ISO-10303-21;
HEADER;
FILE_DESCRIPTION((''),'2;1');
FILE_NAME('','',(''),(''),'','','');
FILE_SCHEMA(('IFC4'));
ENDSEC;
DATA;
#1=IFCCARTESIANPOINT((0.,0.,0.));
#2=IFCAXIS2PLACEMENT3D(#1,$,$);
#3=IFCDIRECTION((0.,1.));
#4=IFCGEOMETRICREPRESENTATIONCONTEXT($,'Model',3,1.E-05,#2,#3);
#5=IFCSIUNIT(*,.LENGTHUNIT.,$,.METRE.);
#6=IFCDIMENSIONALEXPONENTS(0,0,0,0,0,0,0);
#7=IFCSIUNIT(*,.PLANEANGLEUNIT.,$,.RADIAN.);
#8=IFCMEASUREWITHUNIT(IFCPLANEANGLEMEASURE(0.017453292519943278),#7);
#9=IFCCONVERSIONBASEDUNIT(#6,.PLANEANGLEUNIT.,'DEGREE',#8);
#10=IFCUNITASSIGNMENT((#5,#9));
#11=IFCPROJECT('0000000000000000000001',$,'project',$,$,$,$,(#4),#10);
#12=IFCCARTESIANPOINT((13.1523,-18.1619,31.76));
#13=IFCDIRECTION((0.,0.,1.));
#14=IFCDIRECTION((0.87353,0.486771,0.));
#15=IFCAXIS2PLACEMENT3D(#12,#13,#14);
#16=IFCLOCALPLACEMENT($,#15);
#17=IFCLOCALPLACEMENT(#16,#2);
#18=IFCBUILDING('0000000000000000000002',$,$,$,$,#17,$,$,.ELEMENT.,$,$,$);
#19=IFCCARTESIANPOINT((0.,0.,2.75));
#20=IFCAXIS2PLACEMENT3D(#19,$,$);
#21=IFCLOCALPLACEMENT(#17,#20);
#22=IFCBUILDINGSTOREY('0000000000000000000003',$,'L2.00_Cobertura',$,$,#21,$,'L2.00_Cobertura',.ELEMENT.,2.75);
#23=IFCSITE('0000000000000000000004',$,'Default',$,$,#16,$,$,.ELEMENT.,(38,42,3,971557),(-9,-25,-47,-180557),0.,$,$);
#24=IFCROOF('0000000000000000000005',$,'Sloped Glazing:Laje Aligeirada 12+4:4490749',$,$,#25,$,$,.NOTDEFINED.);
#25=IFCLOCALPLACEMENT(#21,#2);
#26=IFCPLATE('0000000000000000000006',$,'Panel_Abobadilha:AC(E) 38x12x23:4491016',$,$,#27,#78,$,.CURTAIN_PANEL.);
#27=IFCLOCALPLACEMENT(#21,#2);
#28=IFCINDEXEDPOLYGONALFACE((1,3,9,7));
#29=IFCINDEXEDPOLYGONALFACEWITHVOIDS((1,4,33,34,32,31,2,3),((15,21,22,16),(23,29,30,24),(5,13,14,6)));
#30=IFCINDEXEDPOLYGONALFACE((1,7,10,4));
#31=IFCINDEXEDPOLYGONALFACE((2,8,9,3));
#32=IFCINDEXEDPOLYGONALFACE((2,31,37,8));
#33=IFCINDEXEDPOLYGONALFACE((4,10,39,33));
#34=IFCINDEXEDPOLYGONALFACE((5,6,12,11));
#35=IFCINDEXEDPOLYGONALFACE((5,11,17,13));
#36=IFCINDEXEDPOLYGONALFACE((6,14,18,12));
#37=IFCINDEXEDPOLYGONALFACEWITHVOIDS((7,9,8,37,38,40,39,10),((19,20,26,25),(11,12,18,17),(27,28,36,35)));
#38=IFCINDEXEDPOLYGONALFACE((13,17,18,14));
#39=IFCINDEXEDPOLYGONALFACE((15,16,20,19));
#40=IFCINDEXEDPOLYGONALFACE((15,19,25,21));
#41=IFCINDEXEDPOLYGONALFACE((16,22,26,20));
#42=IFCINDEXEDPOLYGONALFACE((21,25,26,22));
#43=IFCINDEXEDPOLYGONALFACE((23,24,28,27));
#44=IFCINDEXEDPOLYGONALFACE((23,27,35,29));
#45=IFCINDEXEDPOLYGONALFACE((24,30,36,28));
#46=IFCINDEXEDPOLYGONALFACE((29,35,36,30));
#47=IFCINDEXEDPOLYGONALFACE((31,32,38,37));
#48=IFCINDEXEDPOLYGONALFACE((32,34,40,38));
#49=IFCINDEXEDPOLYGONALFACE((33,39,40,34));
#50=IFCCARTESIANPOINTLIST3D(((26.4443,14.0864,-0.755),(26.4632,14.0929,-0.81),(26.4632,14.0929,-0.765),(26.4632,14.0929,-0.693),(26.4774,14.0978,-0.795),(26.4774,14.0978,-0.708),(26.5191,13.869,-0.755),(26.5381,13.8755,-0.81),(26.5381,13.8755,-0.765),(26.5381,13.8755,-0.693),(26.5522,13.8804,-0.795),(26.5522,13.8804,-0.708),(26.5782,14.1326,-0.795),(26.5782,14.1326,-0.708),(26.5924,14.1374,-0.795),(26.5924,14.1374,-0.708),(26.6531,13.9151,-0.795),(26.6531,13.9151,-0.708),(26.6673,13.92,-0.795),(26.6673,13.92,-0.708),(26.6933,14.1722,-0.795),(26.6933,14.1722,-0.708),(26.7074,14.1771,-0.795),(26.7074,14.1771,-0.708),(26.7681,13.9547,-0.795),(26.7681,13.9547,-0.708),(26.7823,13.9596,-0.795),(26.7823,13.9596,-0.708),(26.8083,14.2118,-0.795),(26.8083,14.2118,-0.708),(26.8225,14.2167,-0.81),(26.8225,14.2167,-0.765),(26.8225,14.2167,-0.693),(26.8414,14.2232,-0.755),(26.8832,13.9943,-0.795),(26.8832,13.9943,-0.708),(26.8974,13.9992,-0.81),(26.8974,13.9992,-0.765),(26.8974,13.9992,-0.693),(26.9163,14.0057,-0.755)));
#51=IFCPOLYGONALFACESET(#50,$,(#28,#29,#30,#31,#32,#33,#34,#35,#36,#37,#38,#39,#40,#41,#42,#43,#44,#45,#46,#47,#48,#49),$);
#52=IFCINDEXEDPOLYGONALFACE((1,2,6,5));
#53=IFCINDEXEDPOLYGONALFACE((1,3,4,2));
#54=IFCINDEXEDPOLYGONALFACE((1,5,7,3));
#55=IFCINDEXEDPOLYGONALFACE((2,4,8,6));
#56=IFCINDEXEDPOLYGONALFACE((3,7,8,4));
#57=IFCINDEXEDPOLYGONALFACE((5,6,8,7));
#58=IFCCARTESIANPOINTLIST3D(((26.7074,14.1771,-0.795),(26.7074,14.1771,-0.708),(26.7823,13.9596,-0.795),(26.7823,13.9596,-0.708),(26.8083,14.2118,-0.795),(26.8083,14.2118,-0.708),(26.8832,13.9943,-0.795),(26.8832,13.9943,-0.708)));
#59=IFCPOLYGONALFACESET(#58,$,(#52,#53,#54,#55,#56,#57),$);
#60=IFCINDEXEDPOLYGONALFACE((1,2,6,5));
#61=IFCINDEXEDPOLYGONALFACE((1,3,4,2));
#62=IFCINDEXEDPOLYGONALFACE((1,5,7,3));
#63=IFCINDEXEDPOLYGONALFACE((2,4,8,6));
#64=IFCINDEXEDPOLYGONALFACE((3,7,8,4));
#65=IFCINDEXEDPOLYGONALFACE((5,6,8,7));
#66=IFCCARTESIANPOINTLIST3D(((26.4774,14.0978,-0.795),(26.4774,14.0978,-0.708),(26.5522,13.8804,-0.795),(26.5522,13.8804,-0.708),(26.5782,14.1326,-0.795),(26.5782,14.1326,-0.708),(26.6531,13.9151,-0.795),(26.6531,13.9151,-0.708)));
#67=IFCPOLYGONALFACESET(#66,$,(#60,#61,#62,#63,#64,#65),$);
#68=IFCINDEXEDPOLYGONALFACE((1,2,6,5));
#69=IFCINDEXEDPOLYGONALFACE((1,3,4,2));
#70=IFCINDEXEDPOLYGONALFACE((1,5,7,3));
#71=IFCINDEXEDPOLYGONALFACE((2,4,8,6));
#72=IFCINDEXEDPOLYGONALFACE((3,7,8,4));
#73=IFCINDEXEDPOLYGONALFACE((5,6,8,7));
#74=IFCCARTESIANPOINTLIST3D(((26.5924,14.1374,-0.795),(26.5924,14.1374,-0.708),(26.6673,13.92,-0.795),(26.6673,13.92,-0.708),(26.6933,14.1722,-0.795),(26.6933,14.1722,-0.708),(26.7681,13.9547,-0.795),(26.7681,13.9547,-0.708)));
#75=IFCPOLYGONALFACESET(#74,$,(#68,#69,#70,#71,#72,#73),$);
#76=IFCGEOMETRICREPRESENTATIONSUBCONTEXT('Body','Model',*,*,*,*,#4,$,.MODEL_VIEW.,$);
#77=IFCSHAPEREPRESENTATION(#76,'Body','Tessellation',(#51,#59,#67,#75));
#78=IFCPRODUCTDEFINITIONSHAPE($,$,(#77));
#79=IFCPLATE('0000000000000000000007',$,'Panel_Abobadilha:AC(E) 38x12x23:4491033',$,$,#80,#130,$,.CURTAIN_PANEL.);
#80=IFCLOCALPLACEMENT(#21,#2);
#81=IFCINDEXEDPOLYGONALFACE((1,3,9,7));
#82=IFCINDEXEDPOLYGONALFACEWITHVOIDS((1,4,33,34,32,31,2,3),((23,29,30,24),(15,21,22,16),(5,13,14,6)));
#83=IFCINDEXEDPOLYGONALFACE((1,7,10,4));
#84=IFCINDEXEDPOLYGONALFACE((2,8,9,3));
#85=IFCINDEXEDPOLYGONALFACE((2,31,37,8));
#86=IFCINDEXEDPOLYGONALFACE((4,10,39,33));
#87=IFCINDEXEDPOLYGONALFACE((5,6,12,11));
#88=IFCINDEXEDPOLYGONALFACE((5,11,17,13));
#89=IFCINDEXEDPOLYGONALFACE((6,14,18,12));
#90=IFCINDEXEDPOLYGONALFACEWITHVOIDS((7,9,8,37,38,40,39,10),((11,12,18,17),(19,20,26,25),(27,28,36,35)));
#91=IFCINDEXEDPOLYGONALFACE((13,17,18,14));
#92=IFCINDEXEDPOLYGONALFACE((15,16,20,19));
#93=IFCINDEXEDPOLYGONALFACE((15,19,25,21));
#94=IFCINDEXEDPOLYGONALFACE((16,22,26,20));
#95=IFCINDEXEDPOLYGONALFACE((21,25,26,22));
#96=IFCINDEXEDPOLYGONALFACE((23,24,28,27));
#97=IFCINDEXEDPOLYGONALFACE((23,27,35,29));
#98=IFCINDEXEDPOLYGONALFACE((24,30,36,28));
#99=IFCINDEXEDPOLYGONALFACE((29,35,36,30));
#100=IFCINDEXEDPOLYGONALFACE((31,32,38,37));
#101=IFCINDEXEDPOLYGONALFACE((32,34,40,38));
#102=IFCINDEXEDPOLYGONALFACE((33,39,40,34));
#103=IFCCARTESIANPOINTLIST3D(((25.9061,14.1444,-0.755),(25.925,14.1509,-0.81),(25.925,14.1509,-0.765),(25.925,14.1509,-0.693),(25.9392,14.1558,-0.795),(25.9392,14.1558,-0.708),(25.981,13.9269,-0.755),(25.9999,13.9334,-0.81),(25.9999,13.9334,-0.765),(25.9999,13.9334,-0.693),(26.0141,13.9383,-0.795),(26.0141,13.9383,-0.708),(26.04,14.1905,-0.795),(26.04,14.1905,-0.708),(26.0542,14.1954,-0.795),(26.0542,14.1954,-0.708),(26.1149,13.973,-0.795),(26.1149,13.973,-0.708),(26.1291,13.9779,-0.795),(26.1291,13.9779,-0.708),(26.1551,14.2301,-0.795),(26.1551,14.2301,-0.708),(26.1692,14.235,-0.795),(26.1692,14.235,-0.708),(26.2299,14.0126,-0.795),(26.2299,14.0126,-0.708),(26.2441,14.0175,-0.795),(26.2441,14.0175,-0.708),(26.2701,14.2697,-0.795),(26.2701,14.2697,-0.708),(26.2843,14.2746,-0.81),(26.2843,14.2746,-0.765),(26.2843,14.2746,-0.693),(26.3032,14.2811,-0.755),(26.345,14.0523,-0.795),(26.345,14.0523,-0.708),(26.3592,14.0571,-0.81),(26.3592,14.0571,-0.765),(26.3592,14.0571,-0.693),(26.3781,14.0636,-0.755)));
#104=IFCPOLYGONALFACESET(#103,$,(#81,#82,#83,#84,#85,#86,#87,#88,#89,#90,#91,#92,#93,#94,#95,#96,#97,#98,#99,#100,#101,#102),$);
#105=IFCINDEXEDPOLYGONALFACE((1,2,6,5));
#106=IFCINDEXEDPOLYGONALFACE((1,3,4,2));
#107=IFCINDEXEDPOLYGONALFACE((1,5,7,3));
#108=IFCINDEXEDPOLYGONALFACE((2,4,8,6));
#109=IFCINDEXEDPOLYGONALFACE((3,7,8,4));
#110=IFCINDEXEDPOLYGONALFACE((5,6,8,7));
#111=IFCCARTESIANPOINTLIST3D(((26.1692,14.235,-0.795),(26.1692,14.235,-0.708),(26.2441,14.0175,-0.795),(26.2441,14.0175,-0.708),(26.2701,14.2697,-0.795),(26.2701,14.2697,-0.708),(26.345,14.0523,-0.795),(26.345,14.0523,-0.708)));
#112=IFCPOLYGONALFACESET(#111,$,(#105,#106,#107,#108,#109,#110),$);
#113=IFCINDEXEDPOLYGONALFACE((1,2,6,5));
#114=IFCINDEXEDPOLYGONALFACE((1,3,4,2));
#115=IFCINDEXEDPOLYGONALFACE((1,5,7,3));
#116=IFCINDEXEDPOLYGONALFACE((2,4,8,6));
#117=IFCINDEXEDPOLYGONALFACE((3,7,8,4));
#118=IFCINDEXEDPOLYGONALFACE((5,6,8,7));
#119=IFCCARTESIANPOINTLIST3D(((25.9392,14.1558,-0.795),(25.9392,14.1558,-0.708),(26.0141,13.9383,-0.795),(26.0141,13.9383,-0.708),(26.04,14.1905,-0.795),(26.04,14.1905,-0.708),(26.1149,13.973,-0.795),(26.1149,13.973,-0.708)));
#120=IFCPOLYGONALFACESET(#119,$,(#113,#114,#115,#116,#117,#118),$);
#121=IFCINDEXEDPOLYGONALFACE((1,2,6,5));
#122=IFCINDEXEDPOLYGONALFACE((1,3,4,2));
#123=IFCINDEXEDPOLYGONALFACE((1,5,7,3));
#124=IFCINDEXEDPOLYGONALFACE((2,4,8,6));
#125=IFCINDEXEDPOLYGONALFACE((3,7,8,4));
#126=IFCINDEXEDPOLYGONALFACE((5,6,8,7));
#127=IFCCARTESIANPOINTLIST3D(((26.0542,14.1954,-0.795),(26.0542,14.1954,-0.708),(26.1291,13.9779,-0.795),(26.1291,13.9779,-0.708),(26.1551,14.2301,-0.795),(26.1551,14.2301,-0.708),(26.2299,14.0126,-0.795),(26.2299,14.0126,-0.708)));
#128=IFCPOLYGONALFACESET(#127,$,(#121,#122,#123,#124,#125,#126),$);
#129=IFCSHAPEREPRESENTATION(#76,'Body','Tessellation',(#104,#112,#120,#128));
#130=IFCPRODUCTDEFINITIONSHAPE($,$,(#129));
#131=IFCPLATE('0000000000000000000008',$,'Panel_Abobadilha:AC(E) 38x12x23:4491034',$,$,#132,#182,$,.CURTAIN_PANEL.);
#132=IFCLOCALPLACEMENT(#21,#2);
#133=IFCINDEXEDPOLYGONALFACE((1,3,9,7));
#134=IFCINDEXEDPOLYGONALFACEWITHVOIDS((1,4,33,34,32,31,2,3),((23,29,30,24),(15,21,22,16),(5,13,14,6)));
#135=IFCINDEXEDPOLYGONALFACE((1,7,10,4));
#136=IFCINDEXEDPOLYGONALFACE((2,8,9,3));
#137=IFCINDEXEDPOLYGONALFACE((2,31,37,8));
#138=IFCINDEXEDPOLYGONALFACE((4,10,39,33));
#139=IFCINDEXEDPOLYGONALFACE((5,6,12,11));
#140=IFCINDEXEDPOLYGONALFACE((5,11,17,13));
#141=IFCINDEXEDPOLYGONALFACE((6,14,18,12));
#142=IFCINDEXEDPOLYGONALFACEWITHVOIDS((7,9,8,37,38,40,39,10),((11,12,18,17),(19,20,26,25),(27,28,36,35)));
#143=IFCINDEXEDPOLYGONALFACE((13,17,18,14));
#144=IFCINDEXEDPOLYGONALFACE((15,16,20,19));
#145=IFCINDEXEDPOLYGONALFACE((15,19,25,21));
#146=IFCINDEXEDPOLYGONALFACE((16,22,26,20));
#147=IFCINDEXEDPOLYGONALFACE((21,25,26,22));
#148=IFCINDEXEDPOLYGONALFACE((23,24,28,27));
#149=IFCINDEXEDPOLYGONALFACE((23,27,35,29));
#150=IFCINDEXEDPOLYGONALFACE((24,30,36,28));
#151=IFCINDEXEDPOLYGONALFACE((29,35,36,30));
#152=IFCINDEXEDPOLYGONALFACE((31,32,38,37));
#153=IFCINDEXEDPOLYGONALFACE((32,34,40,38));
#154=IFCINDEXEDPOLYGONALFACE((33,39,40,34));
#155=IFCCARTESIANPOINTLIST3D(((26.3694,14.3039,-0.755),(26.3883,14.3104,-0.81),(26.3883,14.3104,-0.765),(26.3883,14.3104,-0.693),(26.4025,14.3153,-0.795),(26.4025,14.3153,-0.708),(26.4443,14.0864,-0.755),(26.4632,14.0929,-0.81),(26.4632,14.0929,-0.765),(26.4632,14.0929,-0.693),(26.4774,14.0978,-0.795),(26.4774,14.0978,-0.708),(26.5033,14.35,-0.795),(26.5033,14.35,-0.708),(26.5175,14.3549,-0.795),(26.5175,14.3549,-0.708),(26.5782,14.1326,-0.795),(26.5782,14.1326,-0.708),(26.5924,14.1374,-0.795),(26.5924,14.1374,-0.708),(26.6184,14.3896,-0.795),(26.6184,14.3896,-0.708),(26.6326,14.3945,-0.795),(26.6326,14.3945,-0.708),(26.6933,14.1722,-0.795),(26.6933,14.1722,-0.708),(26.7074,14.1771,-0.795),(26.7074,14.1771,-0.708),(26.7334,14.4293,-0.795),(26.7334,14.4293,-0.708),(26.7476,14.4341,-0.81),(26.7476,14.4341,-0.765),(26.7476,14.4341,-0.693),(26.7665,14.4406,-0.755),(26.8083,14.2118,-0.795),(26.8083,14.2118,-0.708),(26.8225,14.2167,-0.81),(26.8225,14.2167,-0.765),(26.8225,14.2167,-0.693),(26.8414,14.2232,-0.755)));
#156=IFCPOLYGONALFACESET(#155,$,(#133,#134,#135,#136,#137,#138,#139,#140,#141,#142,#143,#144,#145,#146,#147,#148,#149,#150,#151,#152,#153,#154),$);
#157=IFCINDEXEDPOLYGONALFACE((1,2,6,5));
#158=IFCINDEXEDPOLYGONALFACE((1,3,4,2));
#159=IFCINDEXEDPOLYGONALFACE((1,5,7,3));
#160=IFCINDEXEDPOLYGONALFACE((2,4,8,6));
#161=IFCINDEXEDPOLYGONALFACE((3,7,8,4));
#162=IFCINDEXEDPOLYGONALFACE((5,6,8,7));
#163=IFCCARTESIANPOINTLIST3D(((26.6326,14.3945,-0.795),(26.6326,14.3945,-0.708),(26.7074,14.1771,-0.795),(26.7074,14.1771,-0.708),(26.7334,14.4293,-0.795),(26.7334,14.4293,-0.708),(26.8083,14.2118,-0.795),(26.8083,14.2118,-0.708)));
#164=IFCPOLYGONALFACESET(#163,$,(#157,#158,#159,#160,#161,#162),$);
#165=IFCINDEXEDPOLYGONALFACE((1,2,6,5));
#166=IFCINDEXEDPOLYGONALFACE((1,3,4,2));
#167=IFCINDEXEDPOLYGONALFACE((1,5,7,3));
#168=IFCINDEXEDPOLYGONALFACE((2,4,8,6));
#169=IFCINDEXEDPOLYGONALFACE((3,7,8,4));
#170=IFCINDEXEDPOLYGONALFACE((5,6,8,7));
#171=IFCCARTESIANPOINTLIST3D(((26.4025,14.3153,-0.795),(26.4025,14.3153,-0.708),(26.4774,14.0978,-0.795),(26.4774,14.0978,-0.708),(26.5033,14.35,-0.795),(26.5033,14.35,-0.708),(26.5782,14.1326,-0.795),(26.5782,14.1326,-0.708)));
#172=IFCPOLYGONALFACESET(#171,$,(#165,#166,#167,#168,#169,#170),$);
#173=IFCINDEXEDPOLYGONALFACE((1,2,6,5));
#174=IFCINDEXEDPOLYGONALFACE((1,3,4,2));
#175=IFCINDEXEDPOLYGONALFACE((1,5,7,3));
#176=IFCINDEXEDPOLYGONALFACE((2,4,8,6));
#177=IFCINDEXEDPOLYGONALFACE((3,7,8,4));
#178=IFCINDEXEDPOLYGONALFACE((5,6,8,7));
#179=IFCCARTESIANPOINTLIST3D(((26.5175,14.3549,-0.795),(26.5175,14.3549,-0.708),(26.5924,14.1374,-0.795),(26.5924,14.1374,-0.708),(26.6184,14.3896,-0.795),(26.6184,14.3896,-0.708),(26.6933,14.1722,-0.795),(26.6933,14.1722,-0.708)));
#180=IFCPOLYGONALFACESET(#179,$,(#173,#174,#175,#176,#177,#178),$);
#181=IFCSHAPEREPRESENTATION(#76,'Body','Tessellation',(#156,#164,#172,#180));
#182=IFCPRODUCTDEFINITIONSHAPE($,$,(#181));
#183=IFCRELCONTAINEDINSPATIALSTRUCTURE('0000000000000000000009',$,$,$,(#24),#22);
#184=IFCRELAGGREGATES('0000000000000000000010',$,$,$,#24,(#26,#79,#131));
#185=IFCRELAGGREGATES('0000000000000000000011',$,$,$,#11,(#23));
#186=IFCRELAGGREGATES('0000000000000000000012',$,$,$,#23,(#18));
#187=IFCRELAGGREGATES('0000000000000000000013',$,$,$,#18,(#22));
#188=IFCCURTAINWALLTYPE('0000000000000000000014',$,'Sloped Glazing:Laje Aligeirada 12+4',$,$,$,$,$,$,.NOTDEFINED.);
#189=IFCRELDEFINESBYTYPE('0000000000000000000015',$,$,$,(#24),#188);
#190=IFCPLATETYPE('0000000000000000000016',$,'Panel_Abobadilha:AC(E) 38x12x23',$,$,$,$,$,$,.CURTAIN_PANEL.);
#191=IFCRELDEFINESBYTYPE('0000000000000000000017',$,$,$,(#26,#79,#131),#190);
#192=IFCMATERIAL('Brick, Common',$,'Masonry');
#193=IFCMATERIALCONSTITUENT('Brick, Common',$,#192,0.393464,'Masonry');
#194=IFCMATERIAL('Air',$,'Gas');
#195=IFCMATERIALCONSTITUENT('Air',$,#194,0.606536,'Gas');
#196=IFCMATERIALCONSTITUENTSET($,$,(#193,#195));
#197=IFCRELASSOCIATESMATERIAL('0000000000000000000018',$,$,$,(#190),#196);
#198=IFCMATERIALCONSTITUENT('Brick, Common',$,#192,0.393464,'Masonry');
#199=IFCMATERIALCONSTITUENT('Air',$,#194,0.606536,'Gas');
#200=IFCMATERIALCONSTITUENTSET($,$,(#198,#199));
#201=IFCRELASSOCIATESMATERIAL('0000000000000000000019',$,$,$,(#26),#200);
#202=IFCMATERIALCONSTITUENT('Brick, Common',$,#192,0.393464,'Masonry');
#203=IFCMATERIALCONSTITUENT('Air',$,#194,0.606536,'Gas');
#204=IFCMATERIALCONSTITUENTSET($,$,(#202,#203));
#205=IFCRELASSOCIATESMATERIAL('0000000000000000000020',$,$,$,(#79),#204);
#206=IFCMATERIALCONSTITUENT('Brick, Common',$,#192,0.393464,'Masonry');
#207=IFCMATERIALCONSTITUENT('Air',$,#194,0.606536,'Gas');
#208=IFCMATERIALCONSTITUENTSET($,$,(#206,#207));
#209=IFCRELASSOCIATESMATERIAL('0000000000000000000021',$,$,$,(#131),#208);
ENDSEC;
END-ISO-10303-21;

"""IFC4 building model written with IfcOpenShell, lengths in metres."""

from ifc_helpers import new_model, entity, si_unit, converted_unit, direction, frame, origin, place, context, subcontext, project, spatial, indexed_curve, outline, extrude, source, transform, mapped, material, constituent, constituent_set, type_object, type_shapes, element, aggregate, save


model = new_model("IFC4")

# Units and contexts
model_context = context("Model", 3, precision=1e-05, world=origin(), true_north=direction((0.0, 1.0)))
body_context = subcontext(model_context, "Body", "Model", "MODEL_VIEW")
ifc_project = project(units=[si_unit("LENGTHUNIT", "METRE"), converted_unit("PLANEANGLEUNIT", "DEGREE", entity("IfcPlaneAngleMeasure", 0.017453292519943278), si_unit("PLANEANGLEUNIT", "RADIAN"), dimensions=[0, 0, 0, 0, 0, 0, 0])], contexts=[model_context])

# Site, building, storey
site_placement = place(None, frame((13.1523, -18.1619, 31.76), z_axis=(0.0, 0.0, 1.0), x_axis=(0.87353, 0.486771, 0.0)))
site = spatial("IfcSite", under=ifc_project, at=site_placement, Name="Default", CompositionType="ELEMENT", RefLatitude=(38, 42, 3, 971557), RefLongitude=(-9, -25, -47, -180557), RefElevation=0.0)
building_placement = place(site_placement, origin())
building = spatial("IfcBuilding", under=site, at=building_placement, CompositionType="ELEMENT")
storey_placement = place(building_placement, frame((0.0, 0.0, 2.75)))
storey = spatial("IfcBuildingStorey", under=building, at=storey_placement, Name="L2.00_Cobertura", LongName="L2.00_Cobertura", CompositionType="ELEMENT", Elevation=2.75)

# Roof, plates
curtain_wall_type = type_object("IfcCurtainWallType", Name="Sloped Glazing:Laje Aligeirada 12+4", PredefinedType="NOTDEFINED")
roof_placement = place(storey_placement, frame((0.0, 0.0, -2.75)))
roof = element("IfcRoof", 1, at=roof_placement, inside=storey, type_object=curtain_wall_type, Name="Sloped Glazing:Laje Aligeirada 12+4:4490749", PredefinedType="NOTDEFINED")
ifc_material_1 = material(Name="Brick, Common", Category="Masonry")
ifc_material_2 = material(Name="Air", Category="Gas")
ifc_constituent_1 = constituent(ifc_material_1, Name="Brick, Common", Category="Masonry", fraction=0.393464)
ifc_constituent_2 = constituent(ifc_material_2, Name="Air", Category="Gas", fraction=0.606536)
ifc_constituent_set_1 = constituent_set(constituents=[ifc_constituent_1, ifc_constituent_2])
plate_type = type_object("IfcPlateType", Name="Panel_Abobadilha:AC(E) 38x12x23", PredefinedType="CURTAIN_PANEL", material=ifc_constituent_set_1)
shared_shape_1 = source(origin(), body_context, "Body", "SweptSolid", [
    extrude(outline(indexed_curve([(-0.19, -0.0543), (0.19, -0.0543), (0.19, -0.0093), (0.21, 0.0007), (0.19, 0.0628), (-0.19, 0.0628), (-0.21, 0.0007), (-0.19, -0.0093), (-0.19, -0.0543)], self_intersect=False), holes=[indexed_curve([(-0.0683, 0.0477), (-0.0683, -0.0393), (-0.175, -0.0393), (-0.175, 0.0477), (-0.0683, 0.0477)], self_intersect=False), indexed_curve([(0.0533, 0.0477), (0.0533, -0.0393), (-0.0533, -0.0393), (-0.0533, 0.0477), (0.0533, 0.0477)], self_intersect=False), indexed_curve([(0.175, 0.0477), (0.175, -0.0393), (0.0683, -0.0393), (0.0683, 0.0477), (0.175, 0.0477)], self_intersect=False)]), frame((0.0, 0.0543, 0.0)), (0.0, 0.0, 1.0), 0.23),
    extrude(outline(indexed_curve([(-0.0533, -0.0435), (0.0533, -0.0435), (0.0533, 0.0435), (-0.0533, 0.0435), (-0.0533, -0.0435)], self_intersect=False)), frame((0.1217, 0.0585, 0.0), z_axis=(0.0, 0.0, 1.0), x_axis=(-1.0, 0.0, 0.0)), (0.0, 0.0, 1.0), 0.23),
    extrude(outline(indexed_curve([(-0.0533, -0.0435), (0.0533, -0.0435), (0.0533, 0.0435), (-0.0533, 0.0435), (-0.0533, -0.0435)], self_intersect=False)), frame((-0.1217, 0.0585, 0.0), z_axis=(0.0, 0.0, 1.0), x_axis=(-1.0, 0.0, 0.0)), (0.0, 0.0, 1.0), 0.23),
    extrude(outline(indexed_curve([(-0.0533, -0.0435), (0.0533, -0.0435), (0.0533, 0.0435), (-0.0533, 0.0435), (-0.0533, -0.0435)], self_intersect=False)), frame((0.0, 0.0585, 0.0), z_axis=(0.0, 0.0, 1.0), x_axis=(-1.0, 0.0, 0.0)), (0.0, 0.0, 1.0), 0.23),
])
type_shapes(plate_type, [shared_shape_1])
ifc_constituent_3 = constituent(ifc_material_1, Name="Brick, Common", Category="Masonry", fraction=0.393464)
ifc_constituent_4 = constituent(ifc_material_2, Name="Air", Category="Gas", fraction=0.606536)
ifc_constituent_set_2 = constituent_set(constituents=[ifc_constituent_3, ifc_constituent_4])
plate_1_placement = place(roof_placement, frame((26.6428, 14.1548, 1.94), z_axis=(0.325568, -0.945519, 0.0), x_axis=(0.945519, 0.325568, 0.0)))
plate_1 = element("IfcPlate", 2, at=plate_1_placement, type_object=plate_type, material=ifc_constituent_set_2, Name="Panel_Abobadilha:AC(E) 38x12x23:4491016", PredefinedType="CURTAIN_PANEL", context=body_context, shape_type="MappedRepresentation", body=[
    mapped(shared_shape_1, transform((0.0, 0.0, 0.0), scale=1.0)),
])
ifc_constituent_5 = constituent(ifc_material_1, Name="Brick, Common", Category="Masonry", fraction=0.393464)
ifc_constituent_6 = constituent(ifc_material_2, Name="Air", Category="Gas", fraction=0.606536)
ifc_constituent_set_3 = constituent_set(constituents=[ifc_constituent_5, ifc_constituent_6])
plate_2_placement = place(roof_placement, frame((26.1046, 14.2127, 1.94), z_axis=(0.325568, -0.945519, 0.0), x_axis=(0.945519, 0.325568, 0.0)))
plate_2 = element("IfcPlate", 3, at=plate_2_placement, type_object=plate_type, material=ifc_constituent_set_3, Name="Panel_Abobadilha:AC(E) 38x12x23:4491033", PredefinedType="CURTAIN_PANEL", context=body_context, shape_type="MappedRepresentation", body=[
    mapped(shared_shape_1, transform((0.0, 0.0, 0.0), scale=1.0)),
])
ifc_constituent_7 = constituent(ifc_material_1, Name="Brick, Common", Category="Masonry", fraction=0.393464)
ifc_constituent_8 = constituent(ifc_material_2, Name="Air", Category="Gas", fraction=0.606536)
ifc_constituent_set_4 = constituent_set(constituents=[ifc_constituent_7, ifc_constituent_8])
plate_3_placement = place(roof_placement, frame((26.5679, 14.3723, 1.94), z_axis=(0.325568, -0.945519, 0.0), x_axis=(0.945519, 0.325568, 0.0)))
plate_3 = element("IfcPlate", 4, at=plate_3_placement, type_object=plate_type, material=ifc_constituent_set_4, Name="Panel_Abobadilha:AC(E) 38x12x23:4491034", PredefinedType="CURTAIN_PANEL", context=body_context, shape_type="MappedRepresentation", body=[
    mapped(shared_shape_1, transform((0.0, 0.0, 0.0), scale=1.0)),
])
aggregate(roof, [plate_1, plate_2, plate_3])

save(model, "model.ifc")
